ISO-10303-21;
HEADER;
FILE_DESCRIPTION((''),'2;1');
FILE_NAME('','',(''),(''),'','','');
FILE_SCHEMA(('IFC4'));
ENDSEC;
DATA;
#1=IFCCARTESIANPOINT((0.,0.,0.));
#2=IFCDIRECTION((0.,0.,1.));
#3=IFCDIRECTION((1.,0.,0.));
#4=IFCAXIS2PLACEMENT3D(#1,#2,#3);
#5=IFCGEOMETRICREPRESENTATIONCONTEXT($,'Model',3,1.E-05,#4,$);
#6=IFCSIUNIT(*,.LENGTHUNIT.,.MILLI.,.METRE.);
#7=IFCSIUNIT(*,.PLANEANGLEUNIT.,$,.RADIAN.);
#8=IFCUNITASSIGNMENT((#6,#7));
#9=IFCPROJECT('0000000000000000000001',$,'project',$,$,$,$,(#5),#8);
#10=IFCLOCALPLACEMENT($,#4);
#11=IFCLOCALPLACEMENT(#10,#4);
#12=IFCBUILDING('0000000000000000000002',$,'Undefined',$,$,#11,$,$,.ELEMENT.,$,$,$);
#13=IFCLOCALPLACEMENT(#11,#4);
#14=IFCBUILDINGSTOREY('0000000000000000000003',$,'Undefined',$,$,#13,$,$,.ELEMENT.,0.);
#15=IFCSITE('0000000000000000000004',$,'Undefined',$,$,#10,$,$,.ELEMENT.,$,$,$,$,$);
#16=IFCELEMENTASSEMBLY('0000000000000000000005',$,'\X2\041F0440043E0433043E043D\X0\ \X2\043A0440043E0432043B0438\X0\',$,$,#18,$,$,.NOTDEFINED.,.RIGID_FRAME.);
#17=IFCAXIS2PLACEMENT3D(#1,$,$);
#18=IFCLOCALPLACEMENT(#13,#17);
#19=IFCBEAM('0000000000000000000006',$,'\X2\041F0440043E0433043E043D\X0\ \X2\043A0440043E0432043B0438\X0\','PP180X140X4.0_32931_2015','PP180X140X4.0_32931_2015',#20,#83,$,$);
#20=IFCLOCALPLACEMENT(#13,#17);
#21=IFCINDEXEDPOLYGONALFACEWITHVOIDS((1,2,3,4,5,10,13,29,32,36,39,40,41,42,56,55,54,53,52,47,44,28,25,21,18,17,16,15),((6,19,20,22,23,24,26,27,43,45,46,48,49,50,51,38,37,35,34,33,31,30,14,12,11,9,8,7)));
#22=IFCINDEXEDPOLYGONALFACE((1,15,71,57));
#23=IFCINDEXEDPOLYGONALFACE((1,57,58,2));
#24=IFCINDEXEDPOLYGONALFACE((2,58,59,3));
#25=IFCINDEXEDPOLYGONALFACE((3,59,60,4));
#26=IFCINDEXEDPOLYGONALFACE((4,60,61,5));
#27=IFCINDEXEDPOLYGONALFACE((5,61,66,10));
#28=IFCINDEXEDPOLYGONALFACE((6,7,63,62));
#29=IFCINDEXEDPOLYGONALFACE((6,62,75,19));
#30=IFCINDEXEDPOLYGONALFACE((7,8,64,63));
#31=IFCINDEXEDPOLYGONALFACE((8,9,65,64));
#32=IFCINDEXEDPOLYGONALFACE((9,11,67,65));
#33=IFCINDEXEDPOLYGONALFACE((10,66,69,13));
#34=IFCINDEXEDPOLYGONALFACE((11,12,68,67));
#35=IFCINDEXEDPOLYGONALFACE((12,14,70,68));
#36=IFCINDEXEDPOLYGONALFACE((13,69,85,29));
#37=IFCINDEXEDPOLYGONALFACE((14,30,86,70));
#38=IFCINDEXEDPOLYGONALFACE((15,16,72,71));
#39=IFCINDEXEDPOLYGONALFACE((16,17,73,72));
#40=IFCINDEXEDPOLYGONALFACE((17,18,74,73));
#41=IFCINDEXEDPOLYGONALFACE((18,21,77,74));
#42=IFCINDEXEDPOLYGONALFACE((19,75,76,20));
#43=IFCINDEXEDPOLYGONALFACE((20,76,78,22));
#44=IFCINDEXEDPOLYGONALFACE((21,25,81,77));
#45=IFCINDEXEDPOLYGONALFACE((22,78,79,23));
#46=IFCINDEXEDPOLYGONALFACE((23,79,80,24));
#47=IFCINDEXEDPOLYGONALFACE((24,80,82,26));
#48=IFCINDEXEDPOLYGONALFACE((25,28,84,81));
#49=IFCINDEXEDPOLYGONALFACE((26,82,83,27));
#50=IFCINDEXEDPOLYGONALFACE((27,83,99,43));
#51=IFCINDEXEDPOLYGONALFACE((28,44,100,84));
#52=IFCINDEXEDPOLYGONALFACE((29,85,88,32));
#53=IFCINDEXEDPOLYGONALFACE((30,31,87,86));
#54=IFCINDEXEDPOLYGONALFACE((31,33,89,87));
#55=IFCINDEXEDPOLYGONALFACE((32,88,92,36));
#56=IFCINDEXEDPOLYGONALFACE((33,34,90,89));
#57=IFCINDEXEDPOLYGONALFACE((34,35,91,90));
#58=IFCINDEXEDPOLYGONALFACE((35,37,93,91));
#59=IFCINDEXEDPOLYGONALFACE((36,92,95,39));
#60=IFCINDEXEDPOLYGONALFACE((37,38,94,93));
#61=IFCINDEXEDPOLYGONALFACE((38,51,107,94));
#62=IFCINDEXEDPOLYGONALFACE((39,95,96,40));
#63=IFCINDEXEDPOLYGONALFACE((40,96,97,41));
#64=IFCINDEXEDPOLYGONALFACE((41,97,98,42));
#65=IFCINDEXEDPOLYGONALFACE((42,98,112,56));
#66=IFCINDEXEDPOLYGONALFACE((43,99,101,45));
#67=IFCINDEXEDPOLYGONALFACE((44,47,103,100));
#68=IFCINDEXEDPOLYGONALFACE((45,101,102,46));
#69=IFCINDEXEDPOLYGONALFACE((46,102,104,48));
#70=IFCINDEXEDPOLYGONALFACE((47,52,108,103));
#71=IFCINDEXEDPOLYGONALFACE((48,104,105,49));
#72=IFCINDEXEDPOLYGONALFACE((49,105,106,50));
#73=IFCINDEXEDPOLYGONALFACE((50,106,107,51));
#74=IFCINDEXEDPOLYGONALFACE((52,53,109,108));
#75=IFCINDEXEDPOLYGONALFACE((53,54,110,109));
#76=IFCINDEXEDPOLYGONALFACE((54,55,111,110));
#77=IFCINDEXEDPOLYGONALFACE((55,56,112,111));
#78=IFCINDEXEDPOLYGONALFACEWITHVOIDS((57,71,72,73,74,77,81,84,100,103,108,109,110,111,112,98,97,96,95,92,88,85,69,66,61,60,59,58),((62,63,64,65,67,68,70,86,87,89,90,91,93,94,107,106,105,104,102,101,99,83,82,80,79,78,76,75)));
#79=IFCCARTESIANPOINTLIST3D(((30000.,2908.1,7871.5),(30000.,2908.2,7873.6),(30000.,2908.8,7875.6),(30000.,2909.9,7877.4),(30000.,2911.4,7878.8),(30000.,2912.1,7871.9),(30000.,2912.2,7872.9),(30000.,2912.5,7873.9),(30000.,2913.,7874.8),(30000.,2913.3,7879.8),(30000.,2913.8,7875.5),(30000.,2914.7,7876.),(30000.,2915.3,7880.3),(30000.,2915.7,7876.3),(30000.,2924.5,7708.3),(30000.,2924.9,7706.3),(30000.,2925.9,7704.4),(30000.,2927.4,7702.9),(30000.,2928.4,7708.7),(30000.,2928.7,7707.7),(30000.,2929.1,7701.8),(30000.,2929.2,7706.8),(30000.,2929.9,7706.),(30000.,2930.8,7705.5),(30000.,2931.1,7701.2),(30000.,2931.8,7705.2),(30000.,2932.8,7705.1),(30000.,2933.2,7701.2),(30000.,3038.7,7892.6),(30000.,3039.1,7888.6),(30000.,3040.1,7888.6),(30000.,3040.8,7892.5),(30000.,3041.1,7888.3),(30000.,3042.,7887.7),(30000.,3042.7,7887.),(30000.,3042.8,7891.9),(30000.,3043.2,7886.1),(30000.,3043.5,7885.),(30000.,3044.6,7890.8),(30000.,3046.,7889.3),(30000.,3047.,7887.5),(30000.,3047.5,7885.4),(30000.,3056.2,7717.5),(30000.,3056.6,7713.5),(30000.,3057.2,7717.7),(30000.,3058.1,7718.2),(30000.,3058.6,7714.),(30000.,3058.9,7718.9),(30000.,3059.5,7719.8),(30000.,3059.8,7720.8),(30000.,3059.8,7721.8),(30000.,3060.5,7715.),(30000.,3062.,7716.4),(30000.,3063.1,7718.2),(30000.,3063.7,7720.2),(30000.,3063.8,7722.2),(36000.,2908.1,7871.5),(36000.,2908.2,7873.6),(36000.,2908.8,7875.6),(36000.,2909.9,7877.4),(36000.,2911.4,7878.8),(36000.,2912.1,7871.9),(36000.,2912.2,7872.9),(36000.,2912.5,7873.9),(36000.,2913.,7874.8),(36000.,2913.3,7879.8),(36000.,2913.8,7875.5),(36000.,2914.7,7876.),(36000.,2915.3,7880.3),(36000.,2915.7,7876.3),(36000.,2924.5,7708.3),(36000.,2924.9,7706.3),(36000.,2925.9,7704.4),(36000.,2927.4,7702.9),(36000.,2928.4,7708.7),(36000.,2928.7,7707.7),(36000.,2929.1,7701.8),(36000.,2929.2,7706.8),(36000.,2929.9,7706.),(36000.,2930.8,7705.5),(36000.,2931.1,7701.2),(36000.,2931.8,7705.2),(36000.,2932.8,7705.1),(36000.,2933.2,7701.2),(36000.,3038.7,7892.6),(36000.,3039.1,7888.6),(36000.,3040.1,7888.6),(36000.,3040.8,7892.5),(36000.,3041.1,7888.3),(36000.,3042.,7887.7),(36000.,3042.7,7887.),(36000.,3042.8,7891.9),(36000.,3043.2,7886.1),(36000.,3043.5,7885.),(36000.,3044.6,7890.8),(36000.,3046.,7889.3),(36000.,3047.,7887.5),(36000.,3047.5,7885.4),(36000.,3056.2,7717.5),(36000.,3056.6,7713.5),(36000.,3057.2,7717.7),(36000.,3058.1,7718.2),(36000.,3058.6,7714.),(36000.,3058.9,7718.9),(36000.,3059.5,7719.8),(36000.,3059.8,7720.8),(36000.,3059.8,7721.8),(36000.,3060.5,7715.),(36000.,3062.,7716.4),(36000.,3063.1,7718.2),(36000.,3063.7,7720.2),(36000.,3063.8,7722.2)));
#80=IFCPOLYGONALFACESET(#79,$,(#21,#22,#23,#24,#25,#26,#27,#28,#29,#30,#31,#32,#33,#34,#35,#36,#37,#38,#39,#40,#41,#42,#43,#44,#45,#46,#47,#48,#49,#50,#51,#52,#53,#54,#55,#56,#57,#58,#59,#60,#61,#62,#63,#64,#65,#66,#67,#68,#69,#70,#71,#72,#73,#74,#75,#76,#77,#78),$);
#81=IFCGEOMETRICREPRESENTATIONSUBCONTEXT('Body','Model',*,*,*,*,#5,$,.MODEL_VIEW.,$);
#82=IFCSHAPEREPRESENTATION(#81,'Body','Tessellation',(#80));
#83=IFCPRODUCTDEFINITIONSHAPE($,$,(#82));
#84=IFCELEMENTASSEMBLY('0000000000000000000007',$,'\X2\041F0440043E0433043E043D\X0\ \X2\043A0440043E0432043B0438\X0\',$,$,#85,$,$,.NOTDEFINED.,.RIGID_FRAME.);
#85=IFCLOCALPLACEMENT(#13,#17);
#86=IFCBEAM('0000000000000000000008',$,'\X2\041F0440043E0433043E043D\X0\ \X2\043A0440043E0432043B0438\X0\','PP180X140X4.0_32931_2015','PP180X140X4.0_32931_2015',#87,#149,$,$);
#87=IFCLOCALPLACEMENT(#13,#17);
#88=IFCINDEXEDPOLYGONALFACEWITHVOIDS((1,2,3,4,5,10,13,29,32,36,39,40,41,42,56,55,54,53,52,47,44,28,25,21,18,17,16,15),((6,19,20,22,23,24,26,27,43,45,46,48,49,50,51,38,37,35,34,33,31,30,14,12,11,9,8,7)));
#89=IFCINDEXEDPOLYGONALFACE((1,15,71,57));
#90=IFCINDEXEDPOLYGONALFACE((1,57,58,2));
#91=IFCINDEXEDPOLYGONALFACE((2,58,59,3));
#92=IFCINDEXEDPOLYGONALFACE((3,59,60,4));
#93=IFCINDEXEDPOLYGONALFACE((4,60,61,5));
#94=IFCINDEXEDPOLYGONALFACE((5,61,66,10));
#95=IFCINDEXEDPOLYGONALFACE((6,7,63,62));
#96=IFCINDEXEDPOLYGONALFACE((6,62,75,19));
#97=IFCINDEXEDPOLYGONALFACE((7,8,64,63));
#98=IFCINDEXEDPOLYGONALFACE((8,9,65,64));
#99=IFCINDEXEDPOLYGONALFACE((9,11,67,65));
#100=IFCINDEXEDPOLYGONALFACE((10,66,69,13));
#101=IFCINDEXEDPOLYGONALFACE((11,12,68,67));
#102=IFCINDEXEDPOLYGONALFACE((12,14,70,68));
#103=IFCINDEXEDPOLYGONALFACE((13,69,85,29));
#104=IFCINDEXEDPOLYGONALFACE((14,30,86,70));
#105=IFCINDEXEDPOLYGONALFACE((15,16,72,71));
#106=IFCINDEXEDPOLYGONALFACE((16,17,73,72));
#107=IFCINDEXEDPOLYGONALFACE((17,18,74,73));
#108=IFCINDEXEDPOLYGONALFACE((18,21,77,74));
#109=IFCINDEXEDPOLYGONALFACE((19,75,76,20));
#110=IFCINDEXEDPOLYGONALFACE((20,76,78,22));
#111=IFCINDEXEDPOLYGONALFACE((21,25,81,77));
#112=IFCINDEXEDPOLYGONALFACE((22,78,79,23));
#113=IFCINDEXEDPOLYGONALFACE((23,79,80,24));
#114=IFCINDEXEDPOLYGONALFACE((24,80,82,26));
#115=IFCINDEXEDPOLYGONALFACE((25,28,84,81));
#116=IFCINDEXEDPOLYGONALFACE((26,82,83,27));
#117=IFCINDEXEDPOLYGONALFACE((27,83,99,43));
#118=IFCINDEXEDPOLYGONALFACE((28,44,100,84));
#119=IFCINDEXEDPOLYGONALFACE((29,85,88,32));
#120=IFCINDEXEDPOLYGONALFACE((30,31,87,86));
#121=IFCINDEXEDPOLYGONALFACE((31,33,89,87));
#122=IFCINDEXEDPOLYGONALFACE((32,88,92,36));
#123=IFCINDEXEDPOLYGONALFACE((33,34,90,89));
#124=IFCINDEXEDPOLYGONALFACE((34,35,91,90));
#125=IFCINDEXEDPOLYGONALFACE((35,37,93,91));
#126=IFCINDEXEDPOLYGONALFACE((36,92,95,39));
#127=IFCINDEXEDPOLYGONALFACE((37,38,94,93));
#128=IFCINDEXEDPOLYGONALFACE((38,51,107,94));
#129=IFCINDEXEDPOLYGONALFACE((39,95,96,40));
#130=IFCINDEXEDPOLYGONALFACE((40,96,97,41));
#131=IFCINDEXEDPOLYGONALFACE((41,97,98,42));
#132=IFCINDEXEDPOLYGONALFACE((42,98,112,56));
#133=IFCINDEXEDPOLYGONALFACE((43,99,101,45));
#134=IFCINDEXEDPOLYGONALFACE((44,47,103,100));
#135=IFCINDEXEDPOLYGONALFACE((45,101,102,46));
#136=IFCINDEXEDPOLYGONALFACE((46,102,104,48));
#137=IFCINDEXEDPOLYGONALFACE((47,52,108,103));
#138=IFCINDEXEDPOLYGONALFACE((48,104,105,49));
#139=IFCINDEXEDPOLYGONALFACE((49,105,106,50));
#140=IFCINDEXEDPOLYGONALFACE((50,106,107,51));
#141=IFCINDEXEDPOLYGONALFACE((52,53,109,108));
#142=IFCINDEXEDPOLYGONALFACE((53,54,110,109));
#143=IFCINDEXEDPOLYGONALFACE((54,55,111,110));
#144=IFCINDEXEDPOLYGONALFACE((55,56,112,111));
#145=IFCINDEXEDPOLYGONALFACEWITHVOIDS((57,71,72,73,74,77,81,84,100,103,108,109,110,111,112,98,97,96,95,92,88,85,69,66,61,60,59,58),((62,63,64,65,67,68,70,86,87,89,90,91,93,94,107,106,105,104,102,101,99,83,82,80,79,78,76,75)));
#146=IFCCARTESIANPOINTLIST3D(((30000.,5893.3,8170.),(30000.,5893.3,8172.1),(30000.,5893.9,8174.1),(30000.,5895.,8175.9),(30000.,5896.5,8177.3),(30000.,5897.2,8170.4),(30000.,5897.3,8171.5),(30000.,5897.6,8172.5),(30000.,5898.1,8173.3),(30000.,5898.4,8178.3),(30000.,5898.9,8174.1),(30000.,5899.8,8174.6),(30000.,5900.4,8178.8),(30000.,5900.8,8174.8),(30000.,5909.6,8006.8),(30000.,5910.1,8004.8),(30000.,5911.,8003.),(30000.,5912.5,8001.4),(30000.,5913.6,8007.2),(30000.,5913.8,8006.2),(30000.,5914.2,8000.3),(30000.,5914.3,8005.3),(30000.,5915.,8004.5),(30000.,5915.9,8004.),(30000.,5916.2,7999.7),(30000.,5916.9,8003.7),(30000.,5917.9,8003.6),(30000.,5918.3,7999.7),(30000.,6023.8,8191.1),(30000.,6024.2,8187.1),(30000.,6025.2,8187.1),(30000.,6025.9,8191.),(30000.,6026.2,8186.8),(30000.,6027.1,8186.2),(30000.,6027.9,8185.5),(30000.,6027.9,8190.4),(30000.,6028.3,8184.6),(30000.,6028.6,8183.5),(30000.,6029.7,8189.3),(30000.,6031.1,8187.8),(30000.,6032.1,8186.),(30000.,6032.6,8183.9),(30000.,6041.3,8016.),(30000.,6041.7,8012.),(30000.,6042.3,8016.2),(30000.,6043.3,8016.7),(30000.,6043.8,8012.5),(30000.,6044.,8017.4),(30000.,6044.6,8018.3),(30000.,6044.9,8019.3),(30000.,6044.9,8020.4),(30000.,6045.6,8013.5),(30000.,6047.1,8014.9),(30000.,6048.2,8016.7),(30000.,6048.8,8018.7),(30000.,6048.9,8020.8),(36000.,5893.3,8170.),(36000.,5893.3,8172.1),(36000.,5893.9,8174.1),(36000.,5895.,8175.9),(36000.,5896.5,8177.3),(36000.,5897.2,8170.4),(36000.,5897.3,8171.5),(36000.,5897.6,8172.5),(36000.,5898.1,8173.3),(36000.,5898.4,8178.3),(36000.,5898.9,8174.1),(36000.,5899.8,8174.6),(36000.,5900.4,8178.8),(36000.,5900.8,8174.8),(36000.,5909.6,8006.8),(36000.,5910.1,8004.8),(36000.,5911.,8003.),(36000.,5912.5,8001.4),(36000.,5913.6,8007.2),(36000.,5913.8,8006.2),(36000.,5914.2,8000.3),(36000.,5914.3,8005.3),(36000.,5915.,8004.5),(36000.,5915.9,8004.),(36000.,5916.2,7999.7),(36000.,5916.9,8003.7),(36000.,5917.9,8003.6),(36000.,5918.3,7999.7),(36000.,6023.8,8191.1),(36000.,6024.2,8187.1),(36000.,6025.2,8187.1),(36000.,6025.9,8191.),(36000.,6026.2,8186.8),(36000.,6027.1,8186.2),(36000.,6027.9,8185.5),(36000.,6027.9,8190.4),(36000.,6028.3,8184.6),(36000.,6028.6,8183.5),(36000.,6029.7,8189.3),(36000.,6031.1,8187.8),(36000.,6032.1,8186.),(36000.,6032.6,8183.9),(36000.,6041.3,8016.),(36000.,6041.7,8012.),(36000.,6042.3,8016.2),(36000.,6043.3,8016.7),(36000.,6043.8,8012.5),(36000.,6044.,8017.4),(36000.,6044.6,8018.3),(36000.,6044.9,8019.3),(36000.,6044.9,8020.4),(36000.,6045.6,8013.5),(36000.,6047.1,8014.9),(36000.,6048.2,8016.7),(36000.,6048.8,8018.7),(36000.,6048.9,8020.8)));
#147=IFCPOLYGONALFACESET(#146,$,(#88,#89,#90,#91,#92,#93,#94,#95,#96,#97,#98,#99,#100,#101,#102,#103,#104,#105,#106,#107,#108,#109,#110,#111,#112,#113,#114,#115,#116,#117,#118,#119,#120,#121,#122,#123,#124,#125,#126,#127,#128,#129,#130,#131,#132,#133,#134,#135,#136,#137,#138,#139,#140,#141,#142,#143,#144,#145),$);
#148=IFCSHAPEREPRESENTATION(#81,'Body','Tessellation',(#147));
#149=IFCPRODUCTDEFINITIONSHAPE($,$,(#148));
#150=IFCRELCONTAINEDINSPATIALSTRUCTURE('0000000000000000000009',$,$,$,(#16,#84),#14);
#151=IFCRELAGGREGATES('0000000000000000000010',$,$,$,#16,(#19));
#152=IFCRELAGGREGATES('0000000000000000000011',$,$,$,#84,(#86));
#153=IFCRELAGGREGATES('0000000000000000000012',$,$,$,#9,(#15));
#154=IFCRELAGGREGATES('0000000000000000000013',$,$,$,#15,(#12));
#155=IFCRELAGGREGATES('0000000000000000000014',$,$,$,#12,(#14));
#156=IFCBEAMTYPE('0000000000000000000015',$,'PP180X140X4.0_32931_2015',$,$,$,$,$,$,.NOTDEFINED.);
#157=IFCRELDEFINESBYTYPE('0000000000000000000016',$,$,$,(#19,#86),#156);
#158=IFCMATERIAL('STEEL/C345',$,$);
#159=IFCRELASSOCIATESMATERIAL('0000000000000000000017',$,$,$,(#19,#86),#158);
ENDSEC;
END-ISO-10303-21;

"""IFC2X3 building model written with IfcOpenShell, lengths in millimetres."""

from ifc_helpers import new_model, si_unit, frame, origin_with_axes, origin_2d_with_axis, place, context, subcontext, project, spatial, hollow_rectangle, extrude, material, type_object, element, aggregate, save


model = new_model("IFC2X3")

# Units and contexts
model_context = context("Model", 3, precision=1e-05, world=origin_with_axes())
body_context = subcontext(model_context, "Body", "Model", "MODEL_VIEW")
ifc_project = project(units=[si_unit("LENGTHUNIT", "METRE", prefix="MILLI"), si_unit("PLANEANGLEUNIT", "RADIAN")], contexts=[model_context])

# Site, building, storey
site_placement = place(None, origin_with_axes())
site = spatial("IfcSite", under=ifc_project, at=site_placement, Name="Undefined", CompositionType="ELEMENT")
building_placement = place(site_placement, origin_with_axes())
building = spatial("IfcBuilding", under=site, at=building_placement, Name="Undefined", CompositionType="ELEMENT")
storey_placement = place(building_placement, origin_with_axes())
storey = spatial("IfcBuildingStorey", under=building, at=storey_placement, Name="Undefined", CompositionType="ELEMENT", Elevation=0.0)

# Element assemblies, beams
assembly_1_placement = place(storey_placement, origin_with_axes())
assembly_1 = element("IfcElementAssembly", 1, at=assembly_1_placement, inside=storey, Name="Прогон кровли", AssemblyPlace="NOTDEFINED", PredefinedType="RIGID_FRAME")
ifc_material_1 = material(Name="STEEL/C345")
beam_type_1 = type_object("IfcBeamType", Name="PP180X140X4.0_32931_2015", PredefinedType="NOTDEFINED")
beam_1_placement = place(assembly_1_placement, frame((30000.0, 2986.0, 7796.9), z_axis=(0.0, -0.099504, 0.995037), x_axis=(1.0, 0.0, 0.0)))
beam_1 = element("IfcBeam", 2, at=beam_1_placement, type_object=beam_type_1, material=ifc_material_1, Name="Прогон кровли", Description="PP180X140X4.0_32931_2015", ObjectType="PP180X140X4.0_32931_2015", context=body_context, shape_type="SweptSolid", body=[
    extrude(hollow_rectangle(XDim=140.0, YDim=180.0, WallThickness=4.0, InnerFilletRadius=4.0, OuterFilletRadius=8.0, at=origin_2d_with_axis()), frame((6000.0, 0.0, 0.0), z_axis=(-1.0, 0.0, 0.0), x_axis=(0.0, -1.0, 0.0)), (0.0, 0.0, 1.0), 6000.0),
])
aggregate(assembly_1, [beam_1])
assembly_2_placement = place(storey_placement, origin_with_axes())
assembly_2 = element("IfcElementAssembly", 3, at=assembly_2_placement, inside=storey, Name="Прогон кровли", AssemblyPlace="NOTDEFINED", PredefinedType="RIGID_FRAME")
beam_2_placement = place(assembly_2_placement, frame((30000.0, 5971.1, 8095.4), z_axis=(0.0, -0.099504, 0.995037), x_axis=(1.0, 0.0, 0.0)))
beam_2 = element("IfcBeam", 4, at=beam_2_placement, type_object=beam_type_1, material=ifc_material_1, Name="Прогон кровли", Description="PP180X140X4.0_32931_2015", ObjectType="PP180X140X4.0_32931_2015", context=body_context, shape_type="SweptSolid", body=[
    extrude(hollow_rectangle(XDim=140.0, YDim=180.0, WallThickness=4.0, InnerFilletRadius=4.0, OuterFilletRadius=8.0, at=origin_2d_with_axis()), frame((6000.0, 0.0, 0.0), z_axis=(-1.0, 0.0, 0.0), x_axis=(0.0, -1.0, 0.0)), (0.0, 0.0, 1.0), 6000.0),
])
aggregate(assembly_2, [beam_2])

save(model, "model.ifc")
